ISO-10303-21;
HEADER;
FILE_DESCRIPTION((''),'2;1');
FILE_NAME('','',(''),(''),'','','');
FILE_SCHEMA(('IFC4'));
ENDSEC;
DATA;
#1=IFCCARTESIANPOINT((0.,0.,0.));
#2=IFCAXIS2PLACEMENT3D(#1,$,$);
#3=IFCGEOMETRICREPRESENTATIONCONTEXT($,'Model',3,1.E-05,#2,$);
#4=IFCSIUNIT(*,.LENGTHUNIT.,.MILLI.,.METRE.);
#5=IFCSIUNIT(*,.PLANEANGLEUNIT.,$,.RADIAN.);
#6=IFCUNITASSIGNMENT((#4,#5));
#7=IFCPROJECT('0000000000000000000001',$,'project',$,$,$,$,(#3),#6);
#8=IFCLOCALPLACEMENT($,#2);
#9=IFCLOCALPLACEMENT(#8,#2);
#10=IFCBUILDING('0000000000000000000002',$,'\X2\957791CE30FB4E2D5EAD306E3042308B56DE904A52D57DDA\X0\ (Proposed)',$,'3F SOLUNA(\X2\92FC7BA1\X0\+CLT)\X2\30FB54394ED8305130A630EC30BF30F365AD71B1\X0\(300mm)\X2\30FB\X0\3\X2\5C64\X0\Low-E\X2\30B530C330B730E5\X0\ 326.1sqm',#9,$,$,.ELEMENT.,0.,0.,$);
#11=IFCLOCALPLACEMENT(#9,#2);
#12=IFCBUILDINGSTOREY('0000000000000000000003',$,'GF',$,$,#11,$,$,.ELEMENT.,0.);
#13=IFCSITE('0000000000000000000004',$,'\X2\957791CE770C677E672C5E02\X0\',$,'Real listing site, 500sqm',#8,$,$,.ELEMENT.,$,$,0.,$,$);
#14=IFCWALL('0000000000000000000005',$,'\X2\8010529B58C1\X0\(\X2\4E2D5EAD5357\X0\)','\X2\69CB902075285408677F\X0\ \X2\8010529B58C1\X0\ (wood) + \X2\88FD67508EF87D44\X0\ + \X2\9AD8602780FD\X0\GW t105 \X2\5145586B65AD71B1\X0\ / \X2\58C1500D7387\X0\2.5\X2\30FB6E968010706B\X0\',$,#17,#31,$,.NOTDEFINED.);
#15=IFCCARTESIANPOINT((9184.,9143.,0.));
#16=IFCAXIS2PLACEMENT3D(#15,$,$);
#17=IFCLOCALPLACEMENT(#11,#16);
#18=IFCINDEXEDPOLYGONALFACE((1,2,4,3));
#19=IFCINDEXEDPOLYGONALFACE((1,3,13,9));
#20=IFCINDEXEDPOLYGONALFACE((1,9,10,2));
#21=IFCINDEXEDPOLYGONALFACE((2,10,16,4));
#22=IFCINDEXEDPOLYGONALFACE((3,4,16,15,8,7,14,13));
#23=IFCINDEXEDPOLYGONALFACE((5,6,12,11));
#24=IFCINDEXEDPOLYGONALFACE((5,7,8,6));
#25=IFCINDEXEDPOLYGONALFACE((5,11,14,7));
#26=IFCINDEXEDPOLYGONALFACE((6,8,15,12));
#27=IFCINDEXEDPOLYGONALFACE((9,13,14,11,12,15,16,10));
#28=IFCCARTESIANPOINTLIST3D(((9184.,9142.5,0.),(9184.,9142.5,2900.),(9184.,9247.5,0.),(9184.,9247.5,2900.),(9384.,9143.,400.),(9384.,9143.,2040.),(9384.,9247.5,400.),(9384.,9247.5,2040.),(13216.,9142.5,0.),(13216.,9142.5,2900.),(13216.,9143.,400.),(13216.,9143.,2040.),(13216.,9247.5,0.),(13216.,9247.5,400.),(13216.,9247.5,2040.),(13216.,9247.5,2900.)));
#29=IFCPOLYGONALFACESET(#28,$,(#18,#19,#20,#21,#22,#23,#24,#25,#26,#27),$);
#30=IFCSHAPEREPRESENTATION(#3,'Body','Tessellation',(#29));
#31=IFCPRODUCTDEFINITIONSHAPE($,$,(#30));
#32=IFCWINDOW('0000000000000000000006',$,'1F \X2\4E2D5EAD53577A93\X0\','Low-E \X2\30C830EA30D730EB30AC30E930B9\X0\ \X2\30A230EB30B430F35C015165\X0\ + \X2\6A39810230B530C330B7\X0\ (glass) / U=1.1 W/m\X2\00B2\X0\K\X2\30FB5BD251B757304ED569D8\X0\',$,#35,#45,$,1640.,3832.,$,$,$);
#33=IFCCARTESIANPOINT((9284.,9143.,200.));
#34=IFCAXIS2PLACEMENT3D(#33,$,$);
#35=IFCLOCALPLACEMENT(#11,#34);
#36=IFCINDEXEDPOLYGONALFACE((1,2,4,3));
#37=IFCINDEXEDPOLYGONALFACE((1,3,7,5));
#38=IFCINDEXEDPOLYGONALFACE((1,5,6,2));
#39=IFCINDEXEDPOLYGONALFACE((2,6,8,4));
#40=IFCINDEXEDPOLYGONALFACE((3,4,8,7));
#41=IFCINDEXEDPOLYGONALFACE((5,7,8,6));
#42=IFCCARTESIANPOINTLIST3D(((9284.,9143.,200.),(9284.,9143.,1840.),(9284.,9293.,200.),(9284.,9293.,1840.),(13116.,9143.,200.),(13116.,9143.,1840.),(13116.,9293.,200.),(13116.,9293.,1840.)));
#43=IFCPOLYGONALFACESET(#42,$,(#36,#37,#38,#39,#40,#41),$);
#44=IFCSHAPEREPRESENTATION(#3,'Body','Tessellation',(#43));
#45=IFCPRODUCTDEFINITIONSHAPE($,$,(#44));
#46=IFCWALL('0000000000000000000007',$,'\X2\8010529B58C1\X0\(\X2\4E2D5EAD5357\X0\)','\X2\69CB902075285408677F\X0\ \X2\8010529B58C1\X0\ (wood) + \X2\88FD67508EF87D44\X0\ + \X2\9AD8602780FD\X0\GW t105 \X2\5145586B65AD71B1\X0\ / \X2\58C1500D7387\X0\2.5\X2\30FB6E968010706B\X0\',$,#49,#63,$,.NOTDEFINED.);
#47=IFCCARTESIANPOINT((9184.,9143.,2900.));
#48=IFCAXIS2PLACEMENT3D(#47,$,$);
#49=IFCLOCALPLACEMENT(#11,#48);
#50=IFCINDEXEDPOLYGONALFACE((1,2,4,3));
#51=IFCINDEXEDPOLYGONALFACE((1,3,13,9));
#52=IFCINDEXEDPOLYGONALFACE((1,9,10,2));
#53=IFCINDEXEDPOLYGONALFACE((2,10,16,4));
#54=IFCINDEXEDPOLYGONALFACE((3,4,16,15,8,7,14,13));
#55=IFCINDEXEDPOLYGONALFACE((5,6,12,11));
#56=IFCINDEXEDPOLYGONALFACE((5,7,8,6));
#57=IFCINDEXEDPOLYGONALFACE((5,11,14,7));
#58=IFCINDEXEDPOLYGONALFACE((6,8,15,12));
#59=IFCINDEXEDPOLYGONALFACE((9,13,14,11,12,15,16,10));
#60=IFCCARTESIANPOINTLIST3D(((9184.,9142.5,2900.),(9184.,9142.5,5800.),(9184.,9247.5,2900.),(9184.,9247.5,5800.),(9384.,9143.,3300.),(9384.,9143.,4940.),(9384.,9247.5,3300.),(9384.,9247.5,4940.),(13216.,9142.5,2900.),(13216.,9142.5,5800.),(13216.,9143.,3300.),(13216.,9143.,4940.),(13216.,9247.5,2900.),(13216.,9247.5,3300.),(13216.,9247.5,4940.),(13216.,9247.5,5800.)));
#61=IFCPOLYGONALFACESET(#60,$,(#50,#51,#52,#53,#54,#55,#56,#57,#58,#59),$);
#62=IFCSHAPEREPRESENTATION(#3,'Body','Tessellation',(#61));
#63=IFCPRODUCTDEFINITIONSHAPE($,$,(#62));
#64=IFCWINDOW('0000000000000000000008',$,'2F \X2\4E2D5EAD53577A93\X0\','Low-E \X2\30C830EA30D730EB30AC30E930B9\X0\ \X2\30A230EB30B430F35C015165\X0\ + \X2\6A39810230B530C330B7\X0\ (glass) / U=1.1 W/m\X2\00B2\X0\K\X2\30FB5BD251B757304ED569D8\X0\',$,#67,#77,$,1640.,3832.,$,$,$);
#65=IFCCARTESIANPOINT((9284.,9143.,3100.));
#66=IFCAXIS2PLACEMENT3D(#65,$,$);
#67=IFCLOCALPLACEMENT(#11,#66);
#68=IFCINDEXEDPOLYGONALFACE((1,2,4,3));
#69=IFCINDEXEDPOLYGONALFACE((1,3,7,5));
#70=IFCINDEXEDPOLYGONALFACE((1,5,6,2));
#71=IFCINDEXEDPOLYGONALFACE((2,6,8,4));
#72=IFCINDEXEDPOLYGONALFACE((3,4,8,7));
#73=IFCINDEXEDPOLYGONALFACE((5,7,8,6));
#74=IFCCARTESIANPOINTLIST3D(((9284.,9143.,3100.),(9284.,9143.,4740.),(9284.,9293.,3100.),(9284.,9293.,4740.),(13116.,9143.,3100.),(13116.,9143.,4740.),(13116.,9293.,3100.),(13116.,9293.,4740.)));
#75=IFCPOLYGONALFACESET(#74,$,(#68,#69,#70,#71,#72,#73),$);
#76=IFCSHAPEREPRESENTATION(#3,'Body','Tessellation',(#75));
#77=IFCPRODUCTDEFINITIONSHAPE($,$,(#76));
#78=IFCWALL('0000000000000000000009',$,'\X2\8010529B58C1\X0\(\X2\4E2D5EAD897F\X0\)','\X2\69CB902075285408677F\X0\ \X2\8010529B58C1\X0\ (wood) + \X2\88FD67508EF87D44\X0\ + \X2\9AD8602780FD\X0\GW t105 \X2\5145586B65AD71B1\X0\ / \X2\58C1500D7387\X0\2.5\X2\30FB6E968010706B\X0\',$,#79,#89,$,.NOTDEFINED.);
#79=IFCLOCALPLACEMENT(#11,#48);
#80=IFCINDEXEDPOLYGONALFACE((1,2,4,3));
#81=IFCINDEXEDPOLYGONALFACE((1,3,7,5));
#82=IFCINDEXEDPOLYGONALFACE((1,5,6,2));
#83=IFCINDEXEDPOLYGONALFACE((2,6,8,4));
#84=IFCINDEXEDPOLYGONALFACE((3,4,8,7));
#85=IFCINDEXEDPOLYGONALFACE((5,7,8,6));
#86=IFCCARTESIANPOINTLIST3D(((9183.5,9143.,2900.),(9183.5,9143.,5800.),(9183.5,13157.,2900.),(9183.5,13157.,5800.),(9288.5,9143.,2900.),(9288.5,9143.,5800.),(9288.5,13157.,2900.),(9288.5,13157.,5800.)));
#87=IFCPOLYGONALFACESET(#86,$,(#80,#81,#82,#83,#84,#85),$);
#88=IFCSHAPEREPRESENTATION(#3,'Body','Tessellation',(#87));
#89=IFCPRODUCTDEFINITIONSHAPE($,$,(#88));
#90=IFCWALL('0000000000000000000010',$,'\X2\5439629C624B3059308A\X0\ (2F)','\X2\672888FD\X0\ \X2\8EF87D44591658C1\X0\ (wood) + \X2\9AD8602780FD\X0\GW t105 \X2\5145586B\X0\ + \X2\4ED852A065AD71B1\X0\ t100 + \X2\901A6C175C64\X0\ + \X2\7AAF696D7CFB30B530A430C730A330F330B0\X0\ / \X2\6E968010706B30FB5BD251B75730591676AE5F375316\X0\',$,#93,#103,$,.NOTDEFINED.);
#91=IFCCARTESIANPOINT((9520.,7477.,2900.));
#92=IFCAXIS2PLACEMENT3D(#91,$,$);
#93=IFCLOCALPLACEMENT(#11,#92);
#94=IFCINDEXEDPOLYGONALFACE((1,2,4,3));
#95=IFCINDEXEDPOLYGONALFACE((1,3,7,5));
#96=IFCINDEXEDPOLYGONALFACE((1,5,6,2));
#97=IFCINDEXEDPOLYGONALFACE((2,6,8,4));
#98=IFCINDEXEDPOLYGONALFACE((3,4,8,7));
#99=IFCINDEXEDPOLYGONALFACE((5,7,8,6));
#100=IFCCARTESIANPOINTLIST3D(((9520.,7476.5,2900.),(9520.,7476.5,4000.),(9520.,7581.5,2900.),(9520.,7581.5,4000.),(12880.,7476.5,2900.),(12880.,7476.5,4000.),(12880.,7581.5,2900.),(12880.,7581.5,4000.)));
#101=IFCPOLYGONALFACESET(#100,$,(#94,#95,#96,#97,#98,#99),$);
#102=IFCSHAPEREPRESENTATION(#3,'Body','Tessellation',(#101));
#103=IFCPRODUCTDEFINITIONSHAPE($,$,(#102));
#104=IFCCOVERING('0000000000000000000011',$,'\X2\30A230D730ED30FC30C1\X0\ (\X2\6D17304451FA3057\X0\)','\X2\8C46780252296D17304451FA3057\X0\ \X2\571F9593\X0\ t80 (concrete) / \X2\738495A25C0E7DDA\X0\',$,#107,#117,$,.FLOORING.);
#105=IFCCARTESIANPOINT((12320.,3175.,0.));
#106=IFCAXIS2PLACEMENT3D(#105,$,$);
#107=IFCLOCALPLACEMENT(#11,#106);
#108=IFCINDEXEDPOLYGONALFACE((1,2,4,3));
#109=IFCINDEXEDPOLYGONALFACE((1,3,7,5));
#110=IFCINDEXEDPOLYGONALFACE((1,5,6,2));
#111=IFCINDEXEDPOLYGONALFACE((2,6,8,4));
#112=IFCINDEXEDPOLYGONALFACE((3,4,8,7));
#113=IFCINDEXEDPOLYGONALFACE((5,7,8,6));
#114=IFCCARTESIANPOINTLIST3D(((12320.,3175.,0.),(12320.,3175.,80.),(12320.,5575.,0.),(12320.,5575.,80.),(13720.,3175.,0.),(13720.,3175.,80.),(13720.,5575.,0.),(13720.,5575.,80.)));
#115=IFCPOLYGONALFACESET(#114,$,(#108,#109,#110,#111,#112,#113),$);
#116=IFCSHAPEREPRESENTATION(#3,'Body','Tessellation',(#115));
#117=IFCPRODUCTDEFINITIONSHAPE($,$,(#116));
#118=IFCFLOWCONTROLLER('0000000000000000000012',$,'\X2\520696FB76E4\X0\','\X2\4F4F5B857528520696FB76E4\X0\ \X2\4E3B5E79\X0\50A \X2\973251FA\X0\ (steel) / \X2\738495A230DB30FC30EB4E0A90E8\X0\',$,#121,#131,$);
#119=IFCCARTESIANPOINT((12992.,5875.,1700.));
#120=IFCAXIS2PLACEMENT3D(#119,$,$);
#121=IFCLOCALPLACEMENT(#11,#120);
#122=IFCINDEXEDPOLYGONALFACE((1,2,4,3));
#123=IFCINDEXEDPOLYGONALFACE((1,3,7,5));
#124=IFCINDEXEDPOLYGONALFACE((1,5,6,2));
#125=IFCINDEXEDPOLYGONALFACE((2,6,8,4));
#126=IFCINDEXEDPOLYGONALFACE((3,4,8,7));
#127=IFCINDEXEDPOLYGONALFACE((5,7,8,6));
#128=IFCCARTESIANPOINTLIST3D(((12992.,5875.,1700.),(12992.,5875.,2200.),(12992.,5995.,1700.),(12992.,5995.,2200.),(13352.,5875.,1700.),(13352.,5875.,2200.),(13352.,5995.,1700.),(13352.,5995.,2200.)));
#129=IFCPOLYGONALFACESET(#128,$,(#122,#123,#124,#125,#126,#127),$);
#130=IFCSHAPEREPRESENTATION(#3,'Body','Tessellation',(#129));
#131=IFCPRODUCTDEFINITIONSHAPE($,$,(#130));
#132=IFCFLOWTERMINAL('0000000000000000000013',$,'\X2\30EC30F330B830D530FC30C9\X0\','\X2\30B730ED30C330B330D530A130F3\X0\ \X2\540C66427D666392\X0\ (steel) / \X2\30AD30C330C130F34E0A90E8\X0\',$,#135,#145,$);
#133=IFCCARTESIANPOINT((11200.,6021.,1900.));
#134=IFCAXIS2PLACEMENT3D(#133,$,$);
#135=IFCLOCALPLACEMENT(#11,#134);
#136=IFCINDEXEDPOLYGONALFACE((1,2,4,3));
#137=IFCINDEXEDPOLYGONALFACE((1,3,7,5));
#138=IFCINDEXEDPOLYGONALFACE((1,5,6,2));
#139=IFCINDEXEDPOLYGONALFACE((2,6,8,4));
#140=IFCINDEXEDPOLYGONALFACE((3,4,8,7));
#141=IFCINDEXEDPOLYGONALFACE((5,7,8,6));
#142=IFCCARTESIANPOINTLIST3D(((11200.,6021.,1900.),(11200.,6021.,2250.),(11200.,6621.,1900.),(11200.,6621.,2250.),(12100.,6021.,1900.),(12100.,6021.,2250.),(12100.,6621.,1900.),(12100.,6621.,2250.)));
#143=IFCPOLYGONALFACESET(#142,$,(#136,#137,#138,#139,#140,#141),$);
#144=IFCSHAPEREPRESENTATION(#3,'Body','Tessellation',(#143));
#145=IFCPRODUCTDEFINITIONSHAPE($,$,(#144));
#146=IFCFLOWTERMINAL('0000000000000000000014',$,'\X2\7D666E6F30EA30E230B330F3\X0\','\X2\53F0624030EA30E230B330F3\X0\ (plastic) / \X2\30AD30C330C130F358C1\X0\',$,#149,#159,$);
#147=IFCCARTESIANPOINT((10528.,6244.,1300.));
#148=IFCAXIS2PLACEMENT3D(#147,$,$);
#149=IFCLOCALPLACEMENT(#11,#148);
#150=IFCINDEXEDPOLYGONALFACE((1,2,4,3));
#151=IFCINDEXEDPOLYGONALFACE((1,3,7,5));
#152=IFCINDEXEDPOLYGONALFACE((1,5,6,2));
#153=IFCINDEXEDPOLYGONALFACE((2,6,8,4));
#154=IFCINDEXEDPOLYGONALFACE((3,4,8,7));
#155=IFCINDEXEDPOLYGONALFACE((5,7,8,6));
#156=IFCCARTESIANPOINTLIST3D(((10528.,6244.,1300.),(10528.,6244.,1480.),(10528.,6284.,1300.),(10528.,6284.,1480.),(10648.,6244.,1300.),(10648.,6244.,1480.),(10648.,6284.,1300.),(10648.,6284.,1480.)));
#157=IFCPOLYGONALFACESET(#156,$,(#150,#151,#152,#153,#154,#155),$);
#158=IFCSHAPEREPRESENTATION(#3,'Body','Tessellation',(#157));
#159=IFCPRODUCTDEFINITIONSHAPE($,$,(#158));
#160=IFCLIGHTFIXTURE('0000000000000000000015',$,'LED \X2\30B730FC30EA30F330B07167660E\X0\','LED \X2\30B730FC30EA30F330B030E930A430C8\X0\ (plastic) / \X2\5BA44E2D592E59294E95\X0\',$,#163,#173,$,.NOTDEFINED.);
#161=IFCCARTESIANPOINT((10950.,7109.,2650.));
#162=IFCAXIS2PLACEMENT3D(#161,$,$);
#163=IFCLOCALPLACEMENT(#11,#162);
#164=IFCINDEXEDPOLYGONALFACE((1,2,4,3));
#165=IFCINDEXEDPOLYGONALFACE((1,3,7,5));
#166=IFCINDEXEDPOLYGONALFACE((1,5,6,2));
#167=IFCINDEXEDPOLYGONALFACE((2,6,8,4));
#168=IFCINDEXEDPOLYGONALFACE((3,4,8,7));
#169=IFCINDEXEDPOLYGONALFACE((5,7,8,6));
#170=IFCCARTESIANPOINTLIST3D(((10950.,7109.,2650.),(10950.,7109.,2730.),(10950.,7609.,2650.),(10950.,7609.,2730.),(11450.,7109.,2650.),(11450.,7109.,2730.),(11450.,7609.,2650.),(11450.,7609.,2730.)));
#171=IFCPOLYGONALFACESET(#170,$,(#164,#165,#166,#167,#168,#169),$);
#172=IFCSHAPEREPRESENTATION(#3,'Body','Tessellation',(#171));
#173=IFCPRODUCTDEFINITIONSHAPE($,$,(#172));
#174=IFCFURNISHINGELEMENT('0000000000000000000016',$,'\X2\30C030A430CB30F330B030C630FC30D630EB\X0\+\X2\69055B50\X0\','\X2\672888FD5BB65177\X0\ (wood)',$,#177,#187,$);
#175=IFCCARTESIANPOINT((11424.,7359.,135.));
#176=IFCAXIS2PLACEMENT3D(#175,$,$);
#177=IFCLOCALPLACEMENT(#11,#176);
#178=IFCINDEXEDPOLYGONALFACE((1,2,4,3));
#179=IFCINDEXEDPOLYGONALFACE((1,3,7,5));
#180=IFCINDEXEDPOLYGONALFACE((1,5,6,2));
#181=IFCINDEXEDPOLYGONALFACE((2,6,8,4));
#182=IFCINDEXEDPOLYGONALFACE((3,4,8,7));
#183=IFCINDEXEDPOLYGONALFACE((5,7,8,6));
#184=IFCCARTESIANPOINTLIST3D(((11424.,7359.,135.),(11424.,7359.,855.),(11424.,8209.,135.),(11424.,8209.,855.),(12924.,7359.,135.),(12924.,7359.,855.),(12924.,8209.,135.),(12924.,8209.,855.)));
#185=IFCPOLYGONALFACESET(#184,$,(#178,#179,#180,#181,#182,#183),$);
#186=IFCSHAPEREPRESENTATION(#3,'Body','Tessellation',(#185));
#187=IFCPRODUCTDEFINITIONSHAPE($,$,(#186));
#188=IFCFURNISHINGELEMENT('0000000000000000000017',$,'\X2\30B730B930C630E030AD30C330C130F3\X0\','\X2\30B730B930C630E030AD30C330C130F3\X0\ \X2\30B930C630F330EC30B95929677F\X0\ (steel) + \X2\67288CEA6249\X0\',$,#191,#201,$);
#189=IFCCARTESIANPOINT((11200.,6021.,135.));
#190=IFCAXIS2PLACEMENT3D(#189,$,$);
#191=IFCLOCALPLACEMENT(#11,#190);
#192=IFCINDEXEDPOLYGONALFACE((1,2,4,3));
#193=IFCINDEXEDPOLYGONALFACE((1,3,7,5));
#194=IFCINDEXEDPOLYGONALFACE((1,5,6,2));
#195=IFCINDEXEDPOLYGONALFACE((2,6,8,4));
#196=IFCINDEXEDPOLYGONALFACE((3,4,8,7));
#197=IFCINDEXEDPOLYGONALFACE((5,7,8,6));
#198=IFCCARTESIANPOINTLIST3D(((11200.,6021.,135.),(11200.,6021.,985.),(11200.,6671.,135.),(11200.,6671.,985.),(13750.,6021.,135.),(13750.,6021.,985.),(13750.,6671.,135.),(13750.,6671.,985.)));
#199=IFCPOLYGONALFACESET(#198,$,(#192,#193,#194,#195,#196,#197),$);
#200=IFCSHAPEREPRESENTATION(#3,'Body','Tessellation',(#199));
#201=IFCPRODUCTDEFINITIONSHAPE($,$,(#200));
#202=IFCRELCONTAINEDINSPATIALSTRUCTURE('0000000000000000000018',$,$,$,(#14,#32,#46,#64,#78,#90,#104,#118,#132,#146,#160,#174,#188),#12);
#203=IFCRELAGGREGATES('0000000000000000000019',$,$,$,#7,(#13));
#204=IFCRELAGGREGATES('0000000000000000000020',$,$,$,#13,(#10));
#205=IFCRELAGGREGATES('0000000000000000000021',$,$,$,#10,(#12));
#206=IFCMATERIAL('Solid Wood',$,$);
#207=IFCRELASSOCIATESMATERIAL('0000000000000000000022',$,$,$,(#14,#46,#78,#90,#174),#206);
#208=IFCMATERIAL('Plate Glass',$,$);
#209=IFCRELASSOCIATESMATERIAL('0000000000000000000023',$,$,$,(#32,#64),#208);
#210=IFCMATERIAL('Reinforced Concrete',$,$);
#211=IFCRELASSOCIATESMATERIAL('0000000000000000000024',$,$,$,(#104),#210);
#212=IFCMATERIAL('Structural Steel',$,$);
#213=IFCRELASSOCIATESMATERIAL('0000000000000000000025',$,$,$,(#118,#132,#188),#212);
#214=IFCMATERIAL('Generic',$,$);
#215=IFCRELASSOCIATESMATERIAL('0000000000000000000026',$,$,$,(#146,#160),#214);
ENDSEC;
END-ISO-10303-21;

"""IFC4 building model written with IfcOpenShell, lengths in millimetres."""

from ifc_helpers import new_model, si_unit, frame, frame_2d, origin, place, context, project, spatial, rectangle, extrude, material, element, fill, save


model = new_model("IFC4")

# Units and contexts
model_context = context("Model", 3, precision=1e-05, world=origin())
ifc_project = project(units=[si_unit("LENGTHUNIT", "METRE", prefix="MILLI"), si_unit("PLANEANGLEUNIT", "RADIAN")], contexts=[model_context])

# Site, building, storey
site_placement = place(None, origin())
site = spatial("IfcSite", under=ifc_project, at=site_placement, Name="長野県松本市", ObjectType="Real listing site, 500sqm", CompositionType="ELEMENT", RefElevation=0.0)
building_placement = place(site_placement, origin())
building = spatial("IfcBuilding", under=site, at=building_placement, Name="長野・中庭のある回遊動線 (Proposed)", ObjectType="3F SOLUNA(鋼管+CLT)・吹付けウレタン断熱(300mm)・3層Low-Eサッシュ 326.1sqm", CompositionType="ELEMENT", ElevationOfRefHeight=0.0, ElevationOfTerrain=0.0)
storey_placement = place(building_placement, origin())
storey = spatial("IfcBuildingStorey", under=building, at=storey_placement, Name="GF", CompositionType="ELEMENT", Elevation=0.0)

# Shared definitions
ifc_material_1 = material(Name="Solid Wood")

# Wall, opening, window
wall_1_placement = place(storey_placement, frame((9184.0, 9143.0, 0.0)))
wall_1 = element("IfcWall", 1, at=wall_1_placement, inside=storey, material=ifc_material_1, Name="耐力壁(中庭南)", Description="構造用合板 耐力壁 (wood) + 製材軸組 + 高性能GW t105 充填断熱 / 壁倍率2.5・準耐火", PredefinedType="NOTDEFINED", context=model_context, shape_type="SweptSolid", body=[
    extrude(rectangle(XDim=4032.0, YDim=105.0, at=frame_2d((2016.0, 52.0))), frame((9184.0, 9143.0, 0.0)), (0.0, 0.0, 1.0), 2900.0),
])
opening_1_placement = place(storey_placement, frame((9284.0, 9143.0, 200.0)))
opening_1 = element("IfcOpeningElement", 2, at=opening_1_placement, cuts=wall_1, PredefinedType="NOTDEFINED", context=model_context, shape_type="SweptSolid", body=[
    extrude(rectangle(XDim=3832.0, YDim=150.0, at=frame_2d((1916.0, 75.0))), frame((9284.0, 9143.0, 200.0)), (0.0, 0.0, 1.0), 1640.0),
])
ifc_material_2 = material(Name="Plate Glass")
window_1_placement = place(storey_placement, frame((9284.0, 9143.0, 200.0)))
window_1 = element("IfcWindow", 3, at=window_1_placement, inside=storey, material=ifc_material_2, Name="1F 中庭南窓", Description="Low-E トリプルガラス アルゴン封入 + 樹脂サッシ (glass) / U=1.1 W/m²K・寒冷地仕様", OverallHeight=1640.0, OverallWidth=3832.0, context=model_context, shape_type="SweptSolid", body=[
    extrude(rectangle(XDim=3832.0, YDim=150.0, at=frame_2d((1916.0, 75.0))), frame((9284.0, 9143.0, 200.0)), (0.0, 0.0, 1.0), 1640.0),
])
fill(opening_1, window_1)

# Wall, opening, window
wall_2_placement = place(storey_placement, frame((9184.0, 9143.0, 2900.0)))
wall_2 = element("IfcWall", 4, at=wall_2_placement, inside=storey, material=ifc_material_1, Name="耐力壁(中庭南)", Description="構造用合板 耐力壁 (wood) + 製材軸組 + 高性能GW t105 充填断熱 / 壁倍率2.5・準耐火", PredefinedType="NOTDEFINED", context=model_context, shape_type="SweptSolid", body=[
    extrude(rectangle(XDim=4032.0, YDim=105.0, at=frame_2d((2016.0, 52.0))), frame((9184.0, 9143.0, 2900.0)), (0.0, 0.0, 1.0), 2900.0),
])
opening_2_placement = place(storey_placement, frame((9284.0, 9143.0, 3100.0)))
opening_2 = element("IfcOpeningElement", 5, at=opening_2_placement, cuts=wall_2, PredefinedType="NOTDEFINED", context=model_context, shape_type="SweptSolid", body=[
    extrude(rectangle(XDim=3832.0, YDim=150.0, at=frame_2d((1916.0, 75.0))), frame((9284.0, 9143.0, 3100.0)), (0.0, 0.0, 1.0), 1640.0),
])
window_2_placement = place(storey_placement, frame((9284.0, 9143.0, 3100.0)))
window_2 = element("IfcWindow", 6, at=window_2_placement, inside=storey, material=ifc_material_2, Name="2F 中庭南窓", Description="Low-E トリプルガラス アルゴン封入 + 樹脂サッシ (glass) / U=1.1 W/m²K・寒冷地仕様", OverallHeight=1640.0, OverallWidth=3832.0, context=model_context, shape_type="SweptSolid", body=[
    extrude(rectangle(XDim=3832.0, YDim=150.0, at=frame_2d((1916.0, 75.0))), frame((9284.0, 9143.0, 3100.0)), (0.0, 0.0, 1.0), 1640.0),
])
fill(opening_2, window_2)

# Walls
wall_3_placement = place(storey_placement, frame((9184.0, 9143.0, 2900.0)))
element("IfcWall", 7, at=wall_3_placement, inside=storey, material=ifc_material_1, Name="耐力壁(中庭西)", Description="構造用合板 耐力壁 (wood) + 製材軸組 + 高性能GW t105 充填断熱 / 壁倍率2.5・準耐火", PredefinedType="NOTDEFINED", context=model_context, shape_type="SweptSolid", body=[
    extrude(rectangle(XDim=105.0, YDim=4014.0, at=frame_2d((52.0, 2007.0))), frame((9184.0, 9143.0, 2900.0)), (0.0, 0.0, 1.0), 2900.0),
])
wall_4_placement = place(storey_placement, frame((9520.0, 7477.0, 2900.0)))
element("IfcWall", 8, at=wall_4_placement, inside=storey, material=ifc_material_1, Name="吹抜手すり (2F)", Description="木製 軸組外壁 (wood) + 高性能GW t105 充填 + 付加断熱 t100 + 通気層 + 窯業系サイディング / 準耐火・寒冷地外皮強化", PredefinedType="NOTDEFINED", context=model_context, shape_type="SweptSolid", body=[
    extrude(rectangle(XDim=3360.0, YDim=105.0, at=frame_2d((1680.0, 52.0))), frame((9520.0, 7477.0, 2900.0)), (0.0, 0.0, 1.0), 1100.0),
])

# Covering
ifc_material_3 = material(Name="Reinforced Concrete")
covering_placement = place(storey_placement, frame((12320.0, 3175.0, 0.0)))
element("IfcCovering", 9, at=covering_placement, inside=storey, material=ifc_material_3, Name="アプローチ (洗い出し)", Description="豆砂利洗い出し 土間 t80 (concrete) / 玄関導線", PredefinedType="FLOORING", context=model_context, shape_type="SweptSolid", body=[
    extrude(rectangle(XDim=1400.0, YDim=2400.0, at=frame_2d((700.0, 1200.0))), frame((12320.0, 3175.0, 0.0)), (0.0, 0.0, 1.0), 80.0),
])

# Flow controller
ifc_material_4 = material(Name="Structural Steel")
flow_controller_placement = place(storey_placement, frame((12992.0, 5875.0, 1700.0)))
element("IfcFlowController", 10, at=flow_controller_placement, inside=storey, material=ifc_material_4, Name="分電盤", Description="住宅用分電盤 主幹50A 露出 (steel) / 玄関ホール上部", context=model_context, shape_type="SweptSolid", body=[
    extrude(rectangle(XDim=360.0, YDim=120.0, at=frame_2d((180.0, 60.0))), frame((12992.0, 5875.0, 1700.0)), (0.0, 0.0, 1.0), 500.0),
])

# Flow terminals
flow_terminal_1_placement = place(storey_placement, frame((11200.0, 6021.0, 1900.0)))
element("IfcFlowTerminal", 11, at=flow_terminal_1_placement, inside=storey, material=ifc_material_4, Name="レンジフード", Description="シロッコファン 同時給排 (steel) / キッチン上部", context=model_context, shape_type="SweptSolid", body=[
    extrude(rectangle(XDim=900.0, YDim=600.0, at=frame_2d((450.0, 300.0))), frame((11200.0, 6021.0, 1900.0)), (0.0, 0.0, 1.0), 350.0),
])
ifc_material_5 = material(Name="Generic")
flow_terminal_2_placement = place(storey_placement, frame((10528.0, 6244.0, 1300.0)))
element("IfcFlowTerminal", 12, at=flow_terminal_2_placement, inside=storey, material=ifc_material_5, Name="給湯リモコン", Description="台所リモコン (plastic) / キッチン壁", context=model_context, shape_type="SweptSolid", body=[
    extrude(rectangle(XDim=120.0, YDim=40.0, at=frame_2d((60.0, 20.0))), frame((10528.0, 6244.0, 1300.0)), (0.0, 0.0, 1.0), 180.0),
])

# Light fixture
light_fixture_placement = place(storey_placement, frame((10950.0, 7109.0, 2650.0)))
element("IfcLightFixture", 13, at=light_fixture_placement, inside=storey, material=ifc_material_5, Name="LED シーリング照明", Description="LED シーリングライト (plastic) / 室中央天井", PredefinedType="NOTDEFINED", context=model_context, shape_type="SweptSolid", body=[
    extrude(rectangle(XDim=500.0, YDim=500.0, at=frame_2d((250.0, 250.0))), frame((10950.0, 7109.0, 2650.0)), (0.0, 0.0, 1.0), 80.0),
])

# Furnishing elements
furnishing_1_placement = place(storey_placement, frame((11424.0, 7359.0, 135.0)))
element("IfcFurnishingElement", 14, at=furnishing_1_placement, inside=storey, material=ifc_material_1, Name="ダイニングテーブル+椅子", Description="木製家具 (wood)", context=model_context, shape_type="SweptSolid", body=[
    extrude(rectangle(XDim=1500.0, YDim=850.0, at=frame_2d((750.0, 425.0))), frame((11424.0, 7359.0, 135.0)), (0.0, 0.0, 1.0), 720.0),
])
furnishing_2_placement = place(storey_placement, frame((11200.0, 6021.0, 135.0)))
element("IfcFurnishingElement", 15, at=furnishing_2_placement, inside=storey, material=ifc_material_4, Name="システムキッチン", Description="システムキッチン ステンレス天板 (steel) + 木質扉", context=model_context, shape_type="SweptSolid", body=[
    extrude(rectangle(XDim=2550.0, YDim=650.0, at=frame_2d((1275.0, 325.0))), frame((11200.0, 6021.0, 135.0)), (0.0, 0.0, 1.0), 850.0),
])

save(model, "model.ifc")
